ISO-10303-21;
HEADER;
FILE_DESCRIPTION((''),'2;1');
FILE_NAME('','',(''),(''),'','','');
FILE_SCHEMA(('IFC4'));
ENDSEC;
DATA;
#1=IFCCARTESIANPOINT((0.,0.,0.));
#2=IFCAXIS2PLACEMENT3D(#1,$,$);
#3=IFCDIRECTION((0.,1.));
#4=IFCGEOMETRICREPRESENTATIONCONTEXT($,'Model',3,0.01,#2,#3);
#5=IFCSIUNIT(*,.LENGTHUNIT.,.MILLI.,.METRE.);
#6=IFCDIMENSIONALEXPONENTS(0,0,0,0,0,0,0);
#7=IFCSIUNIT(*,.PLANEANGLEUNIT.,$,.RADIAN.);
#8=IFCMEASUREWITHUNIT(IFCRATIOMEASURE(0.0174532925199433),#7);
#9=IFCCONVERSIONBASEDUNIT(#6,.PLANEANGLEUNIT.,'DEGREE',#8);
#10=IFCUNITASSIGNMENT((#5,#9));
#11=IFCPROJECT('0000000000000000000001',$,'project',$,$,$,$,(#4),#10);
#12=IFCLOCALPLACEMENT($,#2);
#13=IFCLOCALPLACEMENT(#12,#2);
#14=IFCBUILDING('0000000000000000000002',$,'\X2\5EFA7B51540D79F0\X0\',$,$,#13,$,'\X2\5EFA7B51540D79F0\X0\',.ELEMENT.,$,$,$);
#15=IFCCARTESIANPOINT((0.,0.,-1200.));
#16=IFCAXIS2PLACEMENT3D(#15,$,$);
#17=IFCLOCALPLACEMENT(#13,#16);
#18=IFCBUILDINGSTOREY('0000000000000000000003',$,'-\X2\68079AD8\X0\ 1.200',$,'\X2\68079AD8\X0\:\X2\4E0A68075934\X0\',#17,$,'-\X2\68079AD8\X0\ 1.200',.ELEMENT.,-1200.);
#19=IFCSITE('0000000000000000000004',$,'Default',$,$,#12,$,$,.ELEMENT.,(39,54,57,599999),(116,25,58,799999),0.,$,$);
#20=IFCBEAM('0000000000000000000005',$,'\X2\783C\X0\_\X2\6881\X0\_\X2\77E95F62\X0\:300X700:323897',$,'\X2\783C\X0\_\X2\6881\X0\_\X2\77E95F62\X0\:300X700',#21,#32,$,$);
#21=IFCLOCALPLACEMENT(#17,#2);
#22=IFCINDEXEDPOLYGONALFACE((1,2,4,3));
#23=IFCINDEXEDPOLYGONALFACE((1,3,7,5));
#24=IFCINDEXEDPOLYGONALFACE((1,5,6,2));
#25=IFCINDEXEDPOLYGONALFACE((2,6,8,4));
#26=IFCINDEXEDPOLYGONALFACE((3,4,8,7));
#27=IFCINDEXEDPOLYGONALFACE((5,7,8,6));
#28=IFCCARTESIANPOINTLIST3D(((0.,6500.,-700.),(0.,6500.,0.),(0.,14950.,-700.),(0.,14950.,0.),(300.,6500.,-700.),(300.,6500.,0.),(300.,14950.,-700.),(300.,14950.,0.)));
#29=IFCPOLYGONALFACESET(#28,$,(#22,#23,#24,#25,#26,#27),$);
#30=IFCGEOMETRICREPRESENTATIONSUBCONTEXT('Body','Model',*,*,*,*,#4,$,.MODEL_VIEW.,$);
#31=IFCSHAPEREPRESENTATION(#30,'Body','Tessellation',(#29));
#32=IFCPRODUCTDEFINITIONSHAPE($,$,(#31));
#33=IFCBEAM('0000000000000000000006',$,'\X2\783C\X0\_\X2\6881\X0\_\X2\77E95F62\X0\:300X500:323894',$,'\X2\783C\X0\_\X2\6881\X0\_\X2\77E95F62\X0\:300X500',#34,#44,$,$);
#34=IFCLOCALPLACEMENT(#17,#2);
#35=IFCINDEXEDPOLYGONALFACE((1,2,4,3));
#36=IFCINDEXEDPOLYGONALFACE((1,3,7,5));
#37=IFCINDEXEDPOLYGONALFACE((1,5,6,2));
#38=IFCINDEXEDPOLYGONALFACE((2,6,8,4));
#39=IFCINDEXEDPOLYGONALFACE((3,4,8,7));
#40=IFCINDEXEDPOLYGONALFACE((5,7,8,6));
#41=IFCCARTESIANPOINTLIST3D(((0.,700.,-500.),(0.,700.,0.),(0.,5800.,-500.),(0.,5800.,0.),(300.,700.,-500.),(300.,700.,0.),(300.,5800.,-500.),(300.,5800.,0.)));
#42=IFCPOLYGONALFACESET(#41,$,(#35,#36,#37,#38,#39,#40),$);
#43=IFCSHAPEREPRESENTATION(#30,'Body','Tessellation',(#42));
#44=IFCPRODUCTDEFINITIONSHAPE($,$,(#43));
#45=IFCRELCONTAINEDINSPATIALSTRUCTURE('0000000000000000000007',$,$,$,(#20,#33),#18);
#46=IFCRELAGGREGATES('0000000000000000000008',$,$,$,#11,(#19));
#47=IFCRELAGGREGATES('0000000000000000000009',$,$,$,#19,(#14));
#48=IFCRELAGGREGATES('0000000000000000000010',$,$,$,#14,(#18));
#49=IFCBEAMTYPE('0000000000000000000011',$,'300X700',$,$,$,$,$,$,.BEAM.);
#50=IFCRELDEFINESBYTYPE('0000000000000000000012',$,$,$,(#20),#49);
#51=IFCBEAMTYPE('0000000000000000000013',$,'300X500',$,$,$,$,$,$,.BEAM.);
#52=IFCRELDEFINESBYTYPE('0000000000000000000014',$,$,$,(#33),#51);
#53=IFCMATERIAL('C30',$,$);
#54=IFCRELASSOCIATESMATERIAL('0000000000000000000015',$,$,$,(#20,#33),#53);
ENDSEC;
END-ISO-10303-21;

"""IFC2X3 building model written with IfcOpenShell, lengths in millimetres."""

from ifc_helpers import new_model, entity, si_unit, converted_unit, direction, frame, frame_2d, origin, place, context, subcontext, project, spatial, rectangle, extrude, material, type_object, element, save


model = new_model("IFC2X3")

# Units and contexts
model_context = context("Model", 3, precision=0.01, world=origin(), true_north=direction((0.0, 1.0)))
body_context = subcontext(model_context, "Body", "Model", "MODEL_VIEW")
ifc_project = project(units=[si_unit("LENGTHUNIT", "METRE", prefix="MILLI"), converted_unit("PLANEANGLEUNIT", "DEGREE", entity("IfcRatioMeasure", 0.0174532925199433), si_unit("PLANEANGLEUNIT", "RADIAN"), dimensions=[0, 0, 0, 0, 0, 0, 0])], contexts=[model_context])

# Site, building, storey
site_placement = place(None, origin())
site = spatial("IfcSite", under=ifc_project, at=site_placement, Name="Default", CompositionType="ELEMENT", RefLatitude=(39, 54, 57, 599999), RefLongitude=(116, 25, 58, 799999), RefElevation=0.0)
building_placement = place(site_placement, origin())
building = spatial("IfcBuilding", under=site, at=building_placement, Name="建筑名称", LongName="建筑名称", CompositionType="ELEMENT")
storey_placement = place(building_placement, frame((0.0, 0.0, -1200.0)))
storey = spatial("IfcBuildingStorey", under=building, at=storey_placement, Name="-标高 1.200", ObjectType="标高:上标头", LongName="-标高 1.200", CompositionType="ELEMENT", Elevation=-1200.0)

# Shared definitions
ifc_material = material(Name="C30")

# Beams
beam_type_1 = type_object("IfcBeamType", Name="300X700", PredefinedType="BEAM")
beam_1_placement = place(storey_placement, frame((0.0, 6150.0, 0.0), z_axis=(0.0, 0.0, 1.0), x_axis=(0.0, 1.0, 0.0)))
element("IfcBeam", 1, at=beam_1_placement, inside=storey, type_object=beam_type_1, material=ifc_material, Name="砼_梁_矩形:300X700:323897", ObjectType="砼_梁_矩形:300X700", context=body_context, shape_type="SweptSolid", body=[
    extrude(rectangle(XDim=700.0, YDim=300.0, at=frame_2d((0.0, 0.0), x_axis=(1.0, 0.0))), frame((350.0, -150.0, -350.0), z_axis=(1.0, 0.0, 0.0), x_axis=(0.0, 0.0, -1.0)), (0.0, 0.0, 1.0), 8450.0),
])
beam_type_2 = type_object("IfcBeamType", Name="300X500", PredefinedType="BEAM")
beam_2_placement = place(storey_placement, frame((0.0, 0.0, 0.0), z_axis=(0.0, 0.0, 1.0), x_axis=(0.0, 1.0, 0.0)))
element("IfcBeam", 2, at=beam_2_placement, inside=storey, type_object=beam_type_2, material=ifc_material, Name="砼_梁_矩形:300X500:323894", ObjectType="砼_梁_矩形:300X500", context=body_context, shape_type="SweptSolid", body=[
    extrude(rectangle(XDim=500.0, YDim=300.0, at=frame_2d((0.0, 0.0), x_axis=(1.0, 0.0))), frame((700.0, -150.0, -250.0), z_axis=(1.0, 0.0, 0.0), x_axis=(0.0, 0.0, -1.0)), (0.0, 0.0, 1.0), 5100.0),
])

save(model, "model.ifc")
